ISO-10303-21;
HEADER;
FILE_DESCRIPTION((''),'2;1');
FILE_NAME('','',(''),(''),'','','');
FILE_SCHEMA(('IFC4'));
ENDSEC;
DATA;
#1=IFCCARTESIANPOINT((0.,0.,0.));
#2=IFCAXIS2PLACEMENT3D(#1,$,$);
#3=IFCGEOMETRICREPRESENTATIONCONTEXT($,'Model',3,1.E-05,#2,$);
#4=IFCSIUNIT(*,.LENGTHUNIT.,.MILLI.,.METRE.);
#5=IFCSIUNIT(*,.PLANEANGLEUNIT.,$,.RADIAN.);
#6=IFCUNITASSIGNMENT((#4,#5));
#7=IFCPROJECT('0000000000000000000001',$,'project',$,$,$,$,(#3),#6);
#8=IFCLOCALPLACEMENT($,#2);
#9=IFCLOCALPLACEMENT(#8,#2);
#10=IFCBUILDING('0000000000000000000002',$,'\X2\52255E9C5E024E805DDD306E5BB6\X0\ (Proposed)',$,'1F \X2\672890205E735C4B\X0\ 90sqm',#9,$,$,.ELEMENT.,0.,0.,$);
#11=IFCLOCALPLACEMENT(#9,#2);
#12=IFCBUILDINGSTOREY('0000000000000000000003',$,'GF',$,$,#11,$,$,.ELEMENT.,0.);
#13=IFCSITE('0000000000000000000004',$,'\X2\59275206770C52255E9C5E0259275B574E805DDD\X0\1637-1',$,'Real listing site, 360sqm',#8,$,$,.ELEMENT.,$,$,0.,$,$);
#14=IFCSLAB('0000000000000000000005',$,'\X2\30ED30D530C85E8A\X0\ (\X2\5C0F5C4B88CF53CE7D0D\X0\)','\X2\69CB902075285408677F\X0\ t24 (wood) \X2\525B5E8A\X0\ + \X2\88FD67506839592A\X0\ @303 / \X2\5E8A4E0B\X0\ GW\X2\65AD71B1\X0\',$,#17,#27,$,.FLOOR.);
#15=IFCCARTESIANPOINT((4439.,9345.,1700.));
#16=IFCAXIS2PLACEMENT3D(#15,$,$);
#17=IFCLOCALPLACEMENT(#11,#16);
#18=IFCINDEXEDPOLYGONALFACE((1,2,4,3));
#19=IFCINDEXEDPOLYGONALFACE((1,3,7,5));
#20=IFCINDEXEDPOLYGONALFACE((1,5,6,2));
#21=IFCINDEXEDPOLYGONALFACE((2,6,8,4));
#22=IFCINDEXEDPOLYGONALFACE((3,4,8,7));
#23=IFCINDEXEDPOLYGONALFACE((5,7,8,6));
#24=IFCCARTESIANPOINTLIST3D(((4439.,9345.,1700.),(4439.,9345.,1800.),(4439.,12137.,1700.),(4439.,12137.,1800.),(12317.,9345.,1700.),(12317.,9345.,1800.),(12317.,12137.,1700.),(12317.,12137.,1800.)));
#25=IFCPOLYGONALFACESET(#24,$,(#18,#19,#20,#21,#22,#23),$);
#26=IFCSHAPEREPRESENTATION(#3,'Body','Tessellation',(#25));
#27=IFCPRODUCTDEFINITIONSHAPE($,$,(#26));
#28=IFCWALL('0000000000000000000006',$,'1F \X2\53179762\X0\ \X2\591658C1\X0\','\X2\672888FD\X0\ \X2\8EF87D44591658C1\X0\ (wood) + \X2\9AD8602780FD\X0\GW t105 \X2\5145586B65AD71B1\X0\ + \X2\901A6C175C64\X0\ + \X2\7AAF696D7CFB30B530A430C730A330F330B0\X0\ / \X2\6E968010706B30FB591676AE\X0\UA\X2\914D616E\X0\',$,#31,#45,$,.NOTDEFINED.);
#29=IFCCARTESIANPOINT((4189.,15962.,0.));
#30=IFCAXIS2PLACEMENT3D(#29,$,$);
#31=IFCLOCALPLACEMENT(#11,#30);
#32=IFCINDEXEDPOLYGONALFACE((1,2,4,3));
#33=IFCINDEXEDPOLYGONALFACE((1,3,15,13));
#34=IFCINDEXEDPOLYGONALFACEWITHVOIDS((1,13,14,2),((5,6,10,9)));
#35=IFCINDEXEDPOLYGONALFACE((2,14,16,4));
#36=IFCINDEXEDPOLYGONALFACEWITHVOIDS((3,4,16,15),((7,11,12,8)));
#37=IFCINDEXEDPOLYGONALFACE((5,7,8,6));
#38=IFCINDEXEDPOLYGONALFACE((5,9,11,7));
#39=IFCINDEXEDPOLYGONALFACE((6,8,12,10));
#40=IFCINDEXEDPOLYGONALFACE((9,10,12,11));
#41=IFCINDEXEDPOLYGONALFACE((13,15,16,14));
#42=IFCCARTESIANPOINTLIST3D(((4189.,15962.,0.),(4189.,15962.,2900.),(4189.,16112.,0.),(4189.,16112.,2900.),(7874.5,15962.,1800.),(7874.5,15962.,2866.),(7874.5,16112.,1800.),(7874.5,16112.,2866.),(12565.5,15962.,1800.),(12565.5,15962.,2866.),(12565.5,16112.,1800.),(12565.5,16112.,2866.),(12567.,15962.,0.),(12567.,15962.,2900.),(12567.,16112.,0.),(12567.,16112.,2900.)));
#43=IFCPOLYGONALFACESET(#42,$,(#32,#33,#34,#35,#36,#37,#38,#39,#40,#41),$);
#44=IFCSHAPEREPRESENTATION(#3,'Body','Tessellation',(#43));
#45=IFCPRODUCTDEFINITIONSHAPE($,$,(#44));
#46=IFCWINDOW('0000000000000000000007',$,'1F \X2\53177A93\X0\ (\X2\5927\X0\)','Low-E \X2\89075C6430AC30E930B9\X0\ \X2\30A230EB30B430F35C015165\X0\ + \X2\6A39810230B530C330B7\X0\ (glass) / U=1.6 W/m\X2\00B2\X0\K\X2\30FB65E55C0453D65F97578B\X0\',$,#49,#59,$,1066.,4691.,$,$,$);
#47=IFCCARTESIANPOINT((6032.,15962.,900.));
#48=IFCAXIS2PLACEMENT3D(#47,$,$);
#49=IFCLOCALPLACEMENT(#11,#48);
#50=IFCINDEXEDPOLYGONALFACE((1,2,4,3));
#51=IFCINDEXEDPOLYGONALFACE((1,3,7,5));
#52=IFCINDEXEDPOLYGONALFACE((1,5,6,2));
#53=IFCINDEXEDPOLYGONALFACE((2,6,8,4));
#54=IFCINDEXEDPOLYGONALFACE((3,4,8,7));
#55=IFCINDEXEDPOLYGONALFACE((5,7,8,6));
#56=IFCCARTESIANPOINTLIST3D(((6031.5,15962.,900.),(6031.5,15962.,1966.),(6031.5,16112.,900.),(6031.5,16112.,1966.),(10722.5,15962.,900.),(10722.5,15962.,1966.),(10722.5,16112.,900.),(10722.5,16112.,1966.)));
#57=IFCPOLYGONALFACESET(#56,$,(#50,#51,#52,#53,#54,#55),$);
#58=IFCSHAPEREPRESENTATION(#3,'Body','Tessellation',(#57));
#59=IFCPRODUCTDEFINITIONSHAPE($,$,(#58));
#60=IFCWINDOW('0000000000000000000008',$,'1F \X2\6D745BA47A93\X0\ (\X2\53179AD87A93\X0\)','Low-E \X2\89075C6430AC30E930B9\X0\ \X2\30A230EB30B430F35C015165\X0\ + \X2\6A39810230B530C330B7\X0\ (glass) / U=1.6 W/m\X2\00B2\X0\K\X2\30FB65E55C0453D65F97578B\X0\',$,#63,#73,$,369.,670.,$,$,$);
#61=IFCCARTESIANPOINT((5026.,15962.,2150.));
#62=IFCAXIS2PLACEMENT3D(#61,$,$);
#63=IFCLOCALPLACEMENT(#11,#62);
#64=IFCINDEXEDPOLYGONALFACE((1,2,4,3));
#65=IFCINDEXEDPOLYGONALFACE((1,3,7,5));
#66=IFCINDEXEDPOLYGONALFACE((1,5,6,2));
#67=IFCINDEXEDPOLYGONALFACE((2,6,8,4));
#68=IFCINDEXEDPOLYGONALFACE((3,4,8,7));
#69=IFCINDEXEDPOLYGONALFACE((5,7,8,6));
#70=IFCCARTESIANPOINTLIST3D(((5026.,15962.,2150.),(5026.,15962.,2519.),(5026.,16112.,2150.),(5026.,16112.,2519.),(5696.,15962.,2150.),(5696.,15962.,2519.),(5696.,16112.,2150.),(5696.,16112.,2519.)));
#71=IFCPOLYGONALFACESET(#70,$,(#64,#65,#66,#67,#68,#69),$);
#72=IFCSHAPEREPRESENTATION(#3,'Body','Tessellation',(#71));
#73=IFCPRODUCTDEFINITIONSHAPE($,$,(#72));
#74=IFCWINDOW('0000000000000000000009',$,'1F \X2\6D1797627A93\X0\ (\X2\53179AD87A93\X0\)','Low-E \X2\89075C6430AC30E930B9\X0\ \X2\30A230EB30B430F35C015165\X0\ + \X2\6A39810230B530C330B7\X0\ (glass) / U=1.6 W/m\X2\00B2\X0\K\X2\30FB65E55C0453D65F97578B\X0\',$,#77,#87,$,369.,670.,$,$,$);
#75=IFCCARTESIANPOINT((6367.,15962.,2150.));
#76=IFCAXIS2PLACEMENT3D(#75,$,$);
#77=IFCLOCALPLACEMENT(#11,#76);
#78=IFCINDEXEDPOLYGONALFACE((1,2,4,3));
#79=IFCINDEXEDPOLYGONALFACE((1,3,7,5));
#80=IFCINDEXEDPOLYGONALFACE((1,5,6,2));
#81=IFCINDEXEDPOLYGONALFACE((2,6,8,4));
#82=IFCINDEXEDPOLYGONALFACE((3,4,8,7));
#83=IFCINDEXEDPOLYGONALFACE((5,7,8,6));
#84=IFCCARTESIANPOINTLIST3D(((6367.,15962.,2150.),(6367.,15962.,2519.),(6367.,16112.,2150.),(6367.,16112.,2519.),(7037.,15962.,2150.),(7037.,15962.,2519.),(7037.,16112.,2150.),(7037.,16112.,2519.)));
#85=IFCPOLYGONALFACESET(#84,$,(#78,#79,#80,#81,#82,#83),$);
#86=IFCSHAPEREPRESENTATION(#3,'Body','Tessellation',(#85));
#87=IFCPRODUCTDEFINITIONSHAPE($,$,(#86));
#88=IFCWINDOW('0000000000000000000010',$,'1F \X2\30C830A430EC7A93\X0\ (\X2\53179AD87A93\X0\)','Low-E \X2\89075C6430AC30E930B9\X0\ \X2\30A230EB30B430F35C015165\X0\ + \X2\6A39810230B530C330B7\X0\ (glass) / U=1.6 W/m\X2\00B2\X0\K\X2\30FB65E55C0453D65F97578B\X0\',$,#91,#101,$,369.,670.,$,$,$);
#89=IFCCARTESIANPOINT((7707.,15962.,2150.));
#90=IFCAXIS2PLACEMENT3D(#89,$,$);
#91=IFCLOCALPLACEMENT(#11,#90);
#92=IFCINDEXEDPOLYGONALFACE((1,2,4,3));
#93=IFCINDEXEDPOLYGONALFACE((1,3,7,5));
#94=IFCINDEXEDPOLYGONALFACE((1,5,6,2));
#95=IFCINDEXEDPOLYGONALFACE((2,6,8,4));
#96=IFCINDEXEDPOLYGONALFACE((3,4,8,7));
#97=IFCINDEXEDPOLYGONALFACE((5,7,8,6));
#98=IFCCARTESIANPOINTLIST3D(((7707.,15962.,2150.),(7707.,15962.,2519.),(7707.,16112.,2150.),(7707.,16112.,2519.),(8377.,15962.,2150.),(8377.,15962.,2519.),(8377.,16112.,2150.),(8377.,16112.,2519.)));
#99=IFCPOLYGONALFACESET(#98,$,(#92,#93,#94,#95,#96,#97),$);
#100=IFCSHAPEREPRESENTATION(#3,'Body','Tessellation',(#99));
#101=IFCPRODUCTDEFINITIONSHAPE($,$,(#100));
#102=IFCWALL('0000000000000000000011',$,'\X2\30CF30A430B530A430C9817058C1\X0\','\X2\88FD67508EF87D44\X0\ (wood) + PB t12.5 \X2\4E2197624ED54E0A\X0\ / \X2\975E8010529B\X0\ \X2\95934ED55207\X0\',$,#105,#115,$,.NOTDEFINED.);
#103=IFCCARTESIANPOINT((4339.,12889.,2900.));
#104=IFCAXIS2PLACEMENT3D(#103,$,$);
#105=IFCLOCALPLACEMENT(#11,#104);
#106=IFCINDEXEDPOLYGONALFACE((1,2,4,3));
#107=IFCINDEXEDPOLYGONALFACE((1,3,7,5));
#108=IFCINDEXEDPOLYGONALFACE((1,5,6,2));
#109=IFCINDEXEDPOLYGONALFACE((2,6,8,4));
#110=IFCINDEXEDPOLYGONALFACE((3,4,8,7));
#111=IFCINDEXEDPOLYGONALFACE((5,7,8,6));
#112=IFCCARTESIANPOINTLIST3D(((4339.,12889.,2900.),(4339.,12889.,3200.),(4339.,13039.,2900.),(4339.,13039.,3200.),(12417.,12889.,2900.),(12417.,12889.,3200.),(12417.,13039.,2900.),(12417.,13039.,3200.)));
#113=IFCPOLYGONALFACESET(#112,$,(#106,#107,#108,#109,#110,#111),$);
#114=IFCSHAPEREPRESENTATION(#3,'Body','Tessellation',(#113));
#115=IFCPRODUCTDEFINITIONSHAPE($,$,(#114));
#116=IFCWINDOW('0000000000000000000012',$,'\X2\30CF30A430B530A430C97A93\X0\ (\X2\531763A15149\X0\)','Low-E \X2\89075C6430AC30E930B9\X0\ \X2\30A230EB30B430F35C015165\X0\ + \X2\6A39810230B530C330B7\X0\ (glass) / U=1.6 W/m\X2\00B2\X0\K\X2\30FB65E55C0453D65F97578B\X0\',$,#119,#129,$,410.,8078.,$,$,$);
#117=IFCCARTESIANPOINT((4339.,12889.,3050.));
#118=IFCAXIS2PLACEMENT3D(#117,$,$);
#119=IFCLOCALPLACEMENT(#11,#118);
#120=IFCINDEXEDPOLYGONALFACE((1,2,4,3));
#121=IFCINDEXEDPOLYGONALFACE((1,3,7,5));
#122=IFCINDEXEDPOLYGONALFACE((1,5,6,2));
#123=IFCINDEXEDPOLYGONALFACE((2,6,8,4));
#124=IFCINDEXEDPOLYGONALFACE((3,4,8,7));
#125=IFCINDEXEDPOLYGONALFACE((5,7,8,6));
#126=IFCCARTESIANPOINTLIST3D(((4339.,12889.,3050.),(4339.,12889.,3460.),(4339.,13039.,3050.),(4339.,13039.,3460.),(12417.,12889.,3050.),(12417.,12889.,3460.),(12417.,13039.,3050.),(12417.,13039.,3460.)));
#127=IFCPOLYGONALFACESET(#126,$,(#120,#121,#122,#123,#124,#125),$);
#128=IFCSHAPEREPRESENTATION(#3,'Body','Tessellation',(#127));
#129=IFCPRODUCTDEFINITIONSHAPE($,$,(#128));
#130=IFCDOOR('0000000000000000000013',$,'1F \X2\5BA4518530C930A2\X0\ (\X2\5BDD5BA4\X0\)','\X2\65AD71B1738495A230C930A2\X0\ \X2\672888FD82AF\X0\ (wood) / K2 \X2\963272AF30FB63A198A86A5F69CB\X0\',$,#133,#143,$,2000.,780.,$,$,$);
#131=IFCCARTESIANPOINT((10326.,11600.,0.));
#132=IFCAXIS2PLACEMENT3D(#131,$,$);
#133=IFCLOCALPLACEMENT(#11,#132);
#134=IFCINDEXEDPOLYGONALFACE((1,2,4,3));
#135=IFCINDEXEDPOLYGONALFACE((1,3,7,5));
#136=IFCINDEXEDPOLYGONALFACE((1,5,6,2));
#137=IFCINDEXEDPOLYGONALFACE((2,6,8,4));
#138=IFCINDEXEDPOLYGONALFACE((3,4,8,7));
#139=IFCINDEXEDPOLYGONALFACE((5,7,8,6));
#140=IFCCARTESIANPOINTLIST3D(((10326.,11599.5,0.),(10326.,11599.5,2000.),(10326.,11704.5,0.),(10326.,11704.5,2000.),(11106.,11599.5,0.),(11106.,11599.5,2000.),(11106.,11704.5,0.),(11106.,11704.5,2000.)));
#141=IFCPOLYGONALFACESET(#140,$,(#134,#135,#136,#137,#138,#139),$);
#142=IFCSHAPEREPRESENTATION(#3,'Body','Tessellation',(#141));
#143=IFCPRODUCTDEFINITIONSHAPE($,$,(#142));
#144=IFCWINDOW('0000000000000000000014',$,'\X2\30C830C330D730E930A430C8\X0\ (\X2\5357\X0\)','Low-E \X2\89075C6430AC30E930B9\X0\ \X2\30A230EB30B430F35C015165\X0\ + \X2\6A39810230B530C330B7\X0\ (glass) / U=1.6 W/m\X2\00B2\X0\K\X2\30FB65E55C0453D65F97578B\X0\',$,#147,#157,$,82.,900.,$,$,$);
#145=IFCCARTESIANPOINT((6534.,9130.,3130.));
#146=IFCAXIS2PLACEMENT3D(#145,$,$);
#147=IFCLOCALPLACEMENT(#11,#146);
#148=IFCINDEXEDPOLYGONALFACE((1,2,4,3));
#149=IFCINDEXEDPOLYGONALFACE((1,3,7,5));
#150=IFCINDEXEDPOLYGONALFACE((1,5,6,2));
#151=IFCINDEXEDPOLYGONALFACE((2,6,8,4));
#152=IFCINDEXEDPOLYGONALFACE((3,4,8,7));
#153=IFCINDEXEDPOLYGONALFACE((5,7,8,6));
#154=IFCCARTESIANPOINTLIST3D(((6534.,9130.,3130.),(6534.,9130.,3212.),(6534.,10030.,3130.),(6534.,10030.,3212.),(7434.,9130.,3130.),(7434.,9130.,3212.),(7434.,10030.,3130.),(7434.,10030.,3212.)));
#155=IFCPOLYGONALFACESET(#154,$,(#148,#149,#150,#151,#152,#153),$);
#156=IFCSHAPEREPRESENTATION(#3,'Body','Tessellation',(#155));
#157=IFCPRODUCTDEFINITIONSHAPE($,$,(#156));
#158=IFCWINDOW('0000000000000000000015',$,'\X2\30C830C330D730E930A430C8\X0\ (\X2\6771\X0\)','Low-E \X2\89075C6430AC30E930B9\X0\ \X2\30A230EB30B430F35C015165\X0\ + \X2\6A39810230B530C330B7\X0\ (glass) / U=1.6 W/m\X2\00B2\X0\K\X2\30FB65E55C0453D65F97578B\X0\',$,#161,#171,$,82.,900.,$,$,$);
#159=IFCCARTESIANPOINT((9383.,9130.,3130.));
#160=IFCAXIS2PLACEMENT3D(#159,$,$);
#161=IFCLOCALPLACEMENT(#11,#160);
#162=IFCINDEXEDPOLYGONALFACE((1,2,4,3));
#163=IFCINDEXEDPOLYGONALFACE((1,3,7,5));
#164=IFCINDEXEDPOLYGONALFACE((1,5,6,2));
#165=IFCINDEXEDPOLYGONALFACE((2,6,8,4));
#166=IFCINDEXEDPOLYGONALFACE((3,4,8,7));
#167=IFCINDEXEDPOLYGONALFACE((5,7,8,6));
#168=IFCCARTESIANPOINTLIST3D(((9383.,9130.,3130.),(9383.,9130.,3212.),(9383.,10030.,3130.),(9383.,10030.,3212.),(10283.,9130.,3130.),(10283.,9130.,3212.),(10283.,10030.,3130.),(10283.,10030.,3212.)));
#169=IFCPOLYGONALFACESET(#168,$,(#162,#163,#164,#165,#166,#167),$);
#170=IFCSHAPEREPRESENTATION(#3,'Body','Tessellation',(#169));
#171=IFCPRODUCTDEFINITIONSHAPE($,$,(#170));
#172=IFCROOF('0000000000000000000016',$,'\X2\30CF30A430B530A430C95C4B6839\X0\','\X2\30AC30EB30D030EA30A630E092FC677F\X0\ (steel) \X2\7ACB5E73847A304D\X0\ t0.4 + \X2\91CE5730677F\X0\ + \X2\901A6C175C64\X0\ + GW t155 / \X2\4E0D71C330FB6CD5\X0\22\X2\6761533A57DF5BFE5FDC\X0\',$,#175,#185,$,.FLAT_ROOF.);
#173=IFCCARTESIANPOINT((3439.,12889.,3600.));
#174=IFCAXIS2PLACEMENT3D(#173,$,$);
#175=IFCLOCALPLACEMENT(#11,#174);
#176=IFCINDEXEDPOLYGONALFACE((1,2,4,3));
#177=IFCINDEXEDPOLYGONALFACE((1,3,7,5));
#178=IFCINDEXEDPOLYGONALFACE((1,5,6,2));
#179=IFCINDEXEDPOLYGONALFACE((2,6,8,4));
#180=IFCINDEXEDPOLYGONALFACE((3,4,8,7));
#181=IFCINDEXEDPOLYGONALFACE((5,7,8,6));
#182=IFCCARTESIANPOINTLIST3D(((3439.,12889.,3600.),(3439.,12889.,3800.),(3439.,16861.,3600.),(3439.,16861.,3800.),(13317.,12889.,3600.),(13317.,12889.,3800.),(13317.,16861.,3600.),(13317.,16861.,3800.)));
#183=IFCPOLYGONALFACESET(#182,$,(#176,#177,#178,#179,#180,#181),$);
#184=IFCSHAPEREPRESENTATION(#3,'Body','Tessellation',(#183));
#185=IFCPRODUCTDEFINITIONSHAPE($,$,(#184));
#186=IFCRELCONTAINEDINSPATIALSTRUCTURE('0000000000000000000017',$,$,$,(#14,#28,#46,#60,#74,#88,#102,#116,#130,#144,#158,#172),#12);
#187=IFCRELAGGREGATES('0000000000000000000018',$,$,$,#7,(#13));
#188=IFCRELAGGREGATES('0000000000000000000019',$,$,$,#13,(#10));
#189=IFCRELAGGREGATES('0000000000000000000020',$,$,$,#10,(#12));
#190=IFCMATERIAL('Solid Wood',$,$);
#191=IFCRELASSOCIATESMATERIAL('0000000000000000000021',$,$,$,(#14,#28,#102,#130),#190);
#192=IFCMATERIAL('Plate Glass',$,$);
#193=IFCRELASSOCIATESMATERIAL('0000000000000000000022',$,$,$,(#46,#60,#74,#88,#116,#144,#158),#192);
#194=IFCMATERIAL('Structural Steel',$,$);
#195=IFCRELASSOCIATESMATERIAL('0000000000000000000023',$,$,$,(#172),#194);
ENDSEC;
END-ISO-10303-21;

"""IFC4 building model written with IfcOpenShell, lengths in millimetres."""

from ifc_helpers import new_model, si_unit, frame, frame_2d, origin, place, context, project, spatial, rectangle, extrude, material, element, fill, save


model = new_model("IFC4")

# Units and contexts
model_context = context("Model", 3, precision=1e-05, world=origin())
ifc_project = project(units=[si_unit("LENGTHUNIT", "METRE", prefix="MILLI"), si_unit("PLANEANGLEUNIT", "RADIAN")], contexts=[model_context])

# Site, building, storey
site_placement = place(None, origin())
site = spatial("IfcSite", under=ifc_project, at=site_placement, Name="大分県別府市大字亀川1637-1", ObjectType="Real listing site, 360sqm", CompositionType="ELEMENT", RefElevation=0.0)
building_placement = place(site_placement, origin())
building = spatial("IfcBuilding", under=site, at=building_placement, Name="別府市亀川の家 (Proposed)", ObjectType="1F 木造平屋 90sqm", CompositionType="ELEMENT", ElevationOfRefHeight=0.0, ElevationOfTerrain=0.0)
storey_placement = place(building_placement, origin())
storey = spatial("IfcBuildingStorey", under=building, at=storey_placement, Name="GF", CompositionType="ELEMENT", Elevation=0.0)

# Slab
ifc_material_1 = material(Name="Solid Wood")
slab_placement = place(storey_placement, frame((4439.0, 9345.0, 1700.0)))
element("IfcSlab", 1, at=slab_placement, inside=storey, material=ifc_material_1, Name="ロフト床 (小屋裏収納)", Description="構造用合板 t24 (wood) 剛床 + 製材根太 @303 / 床下 GW断熱", PredefinedType="FLOOR", context=model_context, shape_type="SweptSolid", body=[
    extrude(rectangle(XDim=7878.0, YDim=2792.0, at=frame_2d((3939.0, 1396.0))), frame((4439.0, 9345.0, 1700.0)), (0.0, 0.0, 1.0), 100.0),
])

# Wall, openings, windows
wall_1_placement = place(storey_placement, frame((4189.0, 15962.0, 0.0)))
wall_1 = element("IfcWall", 2, at=wall_1_placement, inside=storey, material=ifc_material_1, Name="1F 北面 外壁", Description="木製 軸組外壁 (wood) + 高性能GW t105 充填断熱 + 通気層 + 窯業系サイディング / 準耐火・外皮UA配慮", PredefinedType="NOTDEFINED", context=model_context, shape_type="SweptSolid", body=[
    extrude(rectangle(XDim=8378.0, YDim=150.0, at=frame_2d((4189.0, 75.0))), frame((4189.0, 15962.0, 0.0)), (0.0, 0.0, 1.0), 2900.0),
])
opening_1_placement = place(storey_placement, frame((6032.0, 15962.0, 900.0)))
opening_1 = element("IfcOpeningElement", 3, at=opening_1_placement, cuts=wall_1, PredefinedType="NOTDEFINED", context=model_context, shape_type="SweptSolid", body=[
    extrude(rectangle(XDim=4691.0, YDim=150.0, at=frame_2d((2345.0, 75.0))), frame((6032.0, 15962.0, 900.0)), (0.0, 0.0, 1.0), 1066.0),
])
opening_2_placement = place(storey_placement, frame((5026.0, 15962.0, 2150.0)))
opening_2 = element("IfcOpeningElement", 4, at=opening_2_placement, cuts=wall_1, PredefinedType="NOTDEFINED", context=model_context, shape_type="SweptSolid", body=[
    extrude(rectangle(XDim=670.0, YDim=150.0, at=frame_2d((335.0, 75.0))), frame((5026.0, 15962.0, 2150.0)), (0.0, 0.0, 1.0), 369.0),
])
opening_3_placement = place(storey_placement, frame((6367.0, 15962.0, 2150.0)))
opening_3 = element("IfcOpeningElement", 5, at=opening_3_placement, cuts=wall_1, PredefinedType="NOTDEFINED", context=model_context, shape_type="SweptSolid", body=[
    extrude(rectangle(XDim=670.0, YDim=150.0, at=frame_2d((335.0, 75.0))), frame((6367.0, 15962.0, 2150.0)), (0.0, 0.0, 1.0), 369.0),
])
opening_4_placement = place(storey_placement, frame((7707.0, 15962.0, 2150.0)))
opening_4 = element("IfcOpeningElement", 6, at=opening_4_placement, cuts=wall_1, PredefinedType="NOTDEFINED", context=model_context, shape_type="SweptSolid", body=[
    extrude(rectangle(XDim=670.0, YDim=150.0, at=frame_2d((335.0, 75.0))), frame((7707.0, 15962.0, 2150.0)), (0.0, 0.0, 1.0), 369.0),
])
ifc_material_2 = material(Name="Plate Glass")
window_1_placement = place(storey_placement, frame((6032.0, 15962.0, 900.0)))
window_1 = element("IfcWindow", 7, at=window_1_placement, inside=storey, material=ifc_material_2, Name="1F 北窓 (大)", Description="Low-E 複層ガラス アルゴン封入 + 樹脂サッシ (glass) / U=1.6 W/m²K・日射取得型", OverallHeight=1066.0, OverallWidth=4691.0, context=model_context, shape_type="SweptSolid", body=[
    extrude(rectangle(XDim=4691.0, YDim=150.0, at=frame_2d((2345.0, 75.0))), frame((6032.0, 15962.0, 900.0)), (0.0, 0.0, 1.0), 1066.0),
])
fill(opening_1, window_1)
window_2_placement = place(storey_placement, frame((5026.0, 15962.0, 2150.0)))
window_2 = element("IfcWindow", 8, at=window_2_placement, inside=storey, material=ifc_material_2, Name="1F 浴室窓 (北高窓)", Description="Low-E 複層ガラス アルゴン封入 + 樹脂サッシ (glass) / U=1.6 W/m²K・日射取得型", OverallHeight=369.0, OverallWidth=670.0, context=model_context, shape_type="SweptSolid", body=[
    extrude(rectangle(XDim=670.0, YDim=150.0, at=frame_2d((335.0, 75.0))), frame((5026.0, 15962.0, 2150.0)), (0.0, 0.0, 1.0), 369.0),
])
fill(opening_2, window_2)
window_3_placement = place(storey_placement, frame((6367.0, 15962.0, 2150.0)))
window_3 = element("IfcWindow", 9, at=window_3_placement, inside=storey, material=ifc_material_2, Name="1F 洗面窓 (北高窓)", Description="Low-E 複層ガラス アルゴン封入 + 樹脂サッシ (glass) / U=1.6 W/m²K・日射取得型", OverallHeight=369.0, OverallWidth=670.0, context=model_context, shape_type="SweptSolid", body=[
    extrude(rectangle(XDim=670.0, YDim=150.0, at=frame_2d((335.0, 75.0))), frame((6367.0, 15962.0, 2150.0)), (0.0, 0.0, 1.0), 369.0),
])
fill(opening_3, window_3)
window_4_placement = place(storey_placement, frame((7707.0, 15962.0, 2150.0)))
window_4 = element("IfcWindow", 10, at=window_4_placement, inside=storey, material=ifc_material_2, Name="1F トイレ窓 (北高窓)", Description="Low-E 複層ガラス アルゴン封入 + 樹脂サッシ (glass) / U=1.6 W/m²K・日射取得型", OverallHeight=369.0, OverallWidth=670.0, context=model_context, shape_type="SweptSolid", body=[
    extrude(rectangle(XDim=670.0, YDim=150.0, at=frame_2d((335.0, 75.0))), frame((7707.0, 15962.0, 2150.0)), (0.0, 0.0, 1.0), 369.0),
])
fill(opening_4, window_4)

# Wall, opening, window
wall_2_placement = place(storey_placement, frame((4339.0, 12889.0, 2900.0)))
wall_2 = element("IfcWall", 11, at=wall_2_placement, inside=storey, material=ifc_material_1, Name="ハイサイド腰壁", Description="製材軸組 (wood) + PB t12.5 両面仕上 / 非耐力 間仕切", PredefinedType="NOTDEFINED", context=model_context, shape_type="SweptSolid", body=[
    extrude(rectangle(XDim=8078.0, YDim=150.0, at=frame_2d((4039.0, 75.0))), frame((4339.0, 12889.0, 2900.0)), (0.0, 0.0, 1.0), 700.0),
])
opening_5_placement = place(storey_placement, frame((4339.0, 12889.0, 3050.0)))
opening_5 = element("IfcOpeningElement", 12, at=opening_5_placement, cuts=wall_2, PredefinedType="NOTDEFINED", context=model_context, shape_type="SweptSolid", body=[
    extrude(rectangle(XDim=8078.0, YDim=150.0, at=frame_2d((4039.0, 75.0))), frame((4339.0, 12889.0, 3050.0)), (0.0, 0.0, 1.0), 410.0),
])
window_5_placement = place(storey_placement, frame((4339.0, 12889.0, 3050.0)))
window_5 = element("IfcWindow", 13, at=window_5_placement, inside=storey, material=ifc_material_2, Name="ハイサイド窓 (北採光)", Description="Low-E 複層ガラス アルゴン封入 + 樹脂サッシ (glass) / U=1.6 W/m²K・日射取得型", OverallHeight=410.0, OverallWidth=8078.0, context=model_context, shape_type="SweptSolid", body=[
    extrude(rectangle(XDim=8078.0, YDim=150.0, at=frame_2d((4039.0, 75.0))), frame((4339.0, 12889.0, 3050.0)), (0.0, 0.0, 1.0), 410.0),
])
fill(opening_5, window_5)

# Door
door_1_placement = place(storey_placement, frame((10326.0, 11600.0, 0.0)))
element("IfcDoor", 14, at=door_1_placement, inside=storey, material=ifc_material_1, Name="1F 室内ドア (寝室)", Description="断熱玄関ドア 木製芯 (wood) / K2 防犯・採風機構", OverallHeight=2000.0, OverallWidth=780.0, context=model_context, shape_type="SweptSolid", body=[
    extrude(rectangle(XDim=780.0, YDim=105.0, at=frame_2d((390.0, 52.0))), frame((10326.0, 11600.0, 0.0)), (0.0, 0.0, 1.0), 2000.0),
])

# Windows
window_6_placement = place(storey_placement, frame((6534.0, 9130.0, 3130.0)))
element("IfcWindow", 15, at=window_6_placement, inside=storey, material=ifc_material_2, Name="トップライト (南)", Description="Low-E 複層ガラス アルゴン封入 + 樹脂サッシ (glass) / U=1.6 W/m²K・日射取得型", OverallHeight=82.0, OverallWidth=900.0, context=model_context, shape_type="SweptSolid", body=[
    extrude(rectangle(XDim=900.0, YDim=900.0, at=frame_2d((450.0, 450.0))), frame((6534.0, 9130.0, 3130.0)), (0.0, 0.0, 1.0), 82.0),
])
window_7_placement = place(storey_placement, frame((9383.0, 9130.0, 3130.0)))
element("IfcWindow", 16, at=window_7_placement, inside=storey, material=ifc_material_2, Name="トップライト (東)", Description="Low-E 複層ガラス アルゴン封入 + 樹脂サッシ (glass) / U=1.6 W/m²K・日射取得型", OverallHeight=82.0, OverallWidth=900.0, context=model_context, shape_type="SweptSolid", body=[
    extrude(rectangle(XDim=900.0, YDim=900.0, at=frame_2d((450.0, 450.0))), frame((9383.0, 9130.0, 3130.0)), (0.0, 0.0, 1.0), 82.0),
])

# Roof
ifc_material_3 = material(Name="Structural Steel")
roof_placement = place(storey_placement, frame((3439.0, 12889.0, 3600.0)))
element("IfcRoof", 17, at=roof_placement, inside=storey, material=ifc_material_3, Name="ハイサイド屋根", Description="ガルバリウム鋼板 (steel) 立平葺き t0.4 + 野地板 + 通気層 + GW t155 / 不燃・法22条区域対応", PredefinedType="FLAT_ROOF", context=model_context, shape_type="SweptSolid", body=[
    extrude(rectangle(XDim=9878.0, YDim=3972.0, at=frame_2d((4939.0, 1986.0))), frame((3439.0, 12889.0, 3600.0)), (0.0, 0.0, 1.0), 200.0),
])

save(model, "model.ifc")
